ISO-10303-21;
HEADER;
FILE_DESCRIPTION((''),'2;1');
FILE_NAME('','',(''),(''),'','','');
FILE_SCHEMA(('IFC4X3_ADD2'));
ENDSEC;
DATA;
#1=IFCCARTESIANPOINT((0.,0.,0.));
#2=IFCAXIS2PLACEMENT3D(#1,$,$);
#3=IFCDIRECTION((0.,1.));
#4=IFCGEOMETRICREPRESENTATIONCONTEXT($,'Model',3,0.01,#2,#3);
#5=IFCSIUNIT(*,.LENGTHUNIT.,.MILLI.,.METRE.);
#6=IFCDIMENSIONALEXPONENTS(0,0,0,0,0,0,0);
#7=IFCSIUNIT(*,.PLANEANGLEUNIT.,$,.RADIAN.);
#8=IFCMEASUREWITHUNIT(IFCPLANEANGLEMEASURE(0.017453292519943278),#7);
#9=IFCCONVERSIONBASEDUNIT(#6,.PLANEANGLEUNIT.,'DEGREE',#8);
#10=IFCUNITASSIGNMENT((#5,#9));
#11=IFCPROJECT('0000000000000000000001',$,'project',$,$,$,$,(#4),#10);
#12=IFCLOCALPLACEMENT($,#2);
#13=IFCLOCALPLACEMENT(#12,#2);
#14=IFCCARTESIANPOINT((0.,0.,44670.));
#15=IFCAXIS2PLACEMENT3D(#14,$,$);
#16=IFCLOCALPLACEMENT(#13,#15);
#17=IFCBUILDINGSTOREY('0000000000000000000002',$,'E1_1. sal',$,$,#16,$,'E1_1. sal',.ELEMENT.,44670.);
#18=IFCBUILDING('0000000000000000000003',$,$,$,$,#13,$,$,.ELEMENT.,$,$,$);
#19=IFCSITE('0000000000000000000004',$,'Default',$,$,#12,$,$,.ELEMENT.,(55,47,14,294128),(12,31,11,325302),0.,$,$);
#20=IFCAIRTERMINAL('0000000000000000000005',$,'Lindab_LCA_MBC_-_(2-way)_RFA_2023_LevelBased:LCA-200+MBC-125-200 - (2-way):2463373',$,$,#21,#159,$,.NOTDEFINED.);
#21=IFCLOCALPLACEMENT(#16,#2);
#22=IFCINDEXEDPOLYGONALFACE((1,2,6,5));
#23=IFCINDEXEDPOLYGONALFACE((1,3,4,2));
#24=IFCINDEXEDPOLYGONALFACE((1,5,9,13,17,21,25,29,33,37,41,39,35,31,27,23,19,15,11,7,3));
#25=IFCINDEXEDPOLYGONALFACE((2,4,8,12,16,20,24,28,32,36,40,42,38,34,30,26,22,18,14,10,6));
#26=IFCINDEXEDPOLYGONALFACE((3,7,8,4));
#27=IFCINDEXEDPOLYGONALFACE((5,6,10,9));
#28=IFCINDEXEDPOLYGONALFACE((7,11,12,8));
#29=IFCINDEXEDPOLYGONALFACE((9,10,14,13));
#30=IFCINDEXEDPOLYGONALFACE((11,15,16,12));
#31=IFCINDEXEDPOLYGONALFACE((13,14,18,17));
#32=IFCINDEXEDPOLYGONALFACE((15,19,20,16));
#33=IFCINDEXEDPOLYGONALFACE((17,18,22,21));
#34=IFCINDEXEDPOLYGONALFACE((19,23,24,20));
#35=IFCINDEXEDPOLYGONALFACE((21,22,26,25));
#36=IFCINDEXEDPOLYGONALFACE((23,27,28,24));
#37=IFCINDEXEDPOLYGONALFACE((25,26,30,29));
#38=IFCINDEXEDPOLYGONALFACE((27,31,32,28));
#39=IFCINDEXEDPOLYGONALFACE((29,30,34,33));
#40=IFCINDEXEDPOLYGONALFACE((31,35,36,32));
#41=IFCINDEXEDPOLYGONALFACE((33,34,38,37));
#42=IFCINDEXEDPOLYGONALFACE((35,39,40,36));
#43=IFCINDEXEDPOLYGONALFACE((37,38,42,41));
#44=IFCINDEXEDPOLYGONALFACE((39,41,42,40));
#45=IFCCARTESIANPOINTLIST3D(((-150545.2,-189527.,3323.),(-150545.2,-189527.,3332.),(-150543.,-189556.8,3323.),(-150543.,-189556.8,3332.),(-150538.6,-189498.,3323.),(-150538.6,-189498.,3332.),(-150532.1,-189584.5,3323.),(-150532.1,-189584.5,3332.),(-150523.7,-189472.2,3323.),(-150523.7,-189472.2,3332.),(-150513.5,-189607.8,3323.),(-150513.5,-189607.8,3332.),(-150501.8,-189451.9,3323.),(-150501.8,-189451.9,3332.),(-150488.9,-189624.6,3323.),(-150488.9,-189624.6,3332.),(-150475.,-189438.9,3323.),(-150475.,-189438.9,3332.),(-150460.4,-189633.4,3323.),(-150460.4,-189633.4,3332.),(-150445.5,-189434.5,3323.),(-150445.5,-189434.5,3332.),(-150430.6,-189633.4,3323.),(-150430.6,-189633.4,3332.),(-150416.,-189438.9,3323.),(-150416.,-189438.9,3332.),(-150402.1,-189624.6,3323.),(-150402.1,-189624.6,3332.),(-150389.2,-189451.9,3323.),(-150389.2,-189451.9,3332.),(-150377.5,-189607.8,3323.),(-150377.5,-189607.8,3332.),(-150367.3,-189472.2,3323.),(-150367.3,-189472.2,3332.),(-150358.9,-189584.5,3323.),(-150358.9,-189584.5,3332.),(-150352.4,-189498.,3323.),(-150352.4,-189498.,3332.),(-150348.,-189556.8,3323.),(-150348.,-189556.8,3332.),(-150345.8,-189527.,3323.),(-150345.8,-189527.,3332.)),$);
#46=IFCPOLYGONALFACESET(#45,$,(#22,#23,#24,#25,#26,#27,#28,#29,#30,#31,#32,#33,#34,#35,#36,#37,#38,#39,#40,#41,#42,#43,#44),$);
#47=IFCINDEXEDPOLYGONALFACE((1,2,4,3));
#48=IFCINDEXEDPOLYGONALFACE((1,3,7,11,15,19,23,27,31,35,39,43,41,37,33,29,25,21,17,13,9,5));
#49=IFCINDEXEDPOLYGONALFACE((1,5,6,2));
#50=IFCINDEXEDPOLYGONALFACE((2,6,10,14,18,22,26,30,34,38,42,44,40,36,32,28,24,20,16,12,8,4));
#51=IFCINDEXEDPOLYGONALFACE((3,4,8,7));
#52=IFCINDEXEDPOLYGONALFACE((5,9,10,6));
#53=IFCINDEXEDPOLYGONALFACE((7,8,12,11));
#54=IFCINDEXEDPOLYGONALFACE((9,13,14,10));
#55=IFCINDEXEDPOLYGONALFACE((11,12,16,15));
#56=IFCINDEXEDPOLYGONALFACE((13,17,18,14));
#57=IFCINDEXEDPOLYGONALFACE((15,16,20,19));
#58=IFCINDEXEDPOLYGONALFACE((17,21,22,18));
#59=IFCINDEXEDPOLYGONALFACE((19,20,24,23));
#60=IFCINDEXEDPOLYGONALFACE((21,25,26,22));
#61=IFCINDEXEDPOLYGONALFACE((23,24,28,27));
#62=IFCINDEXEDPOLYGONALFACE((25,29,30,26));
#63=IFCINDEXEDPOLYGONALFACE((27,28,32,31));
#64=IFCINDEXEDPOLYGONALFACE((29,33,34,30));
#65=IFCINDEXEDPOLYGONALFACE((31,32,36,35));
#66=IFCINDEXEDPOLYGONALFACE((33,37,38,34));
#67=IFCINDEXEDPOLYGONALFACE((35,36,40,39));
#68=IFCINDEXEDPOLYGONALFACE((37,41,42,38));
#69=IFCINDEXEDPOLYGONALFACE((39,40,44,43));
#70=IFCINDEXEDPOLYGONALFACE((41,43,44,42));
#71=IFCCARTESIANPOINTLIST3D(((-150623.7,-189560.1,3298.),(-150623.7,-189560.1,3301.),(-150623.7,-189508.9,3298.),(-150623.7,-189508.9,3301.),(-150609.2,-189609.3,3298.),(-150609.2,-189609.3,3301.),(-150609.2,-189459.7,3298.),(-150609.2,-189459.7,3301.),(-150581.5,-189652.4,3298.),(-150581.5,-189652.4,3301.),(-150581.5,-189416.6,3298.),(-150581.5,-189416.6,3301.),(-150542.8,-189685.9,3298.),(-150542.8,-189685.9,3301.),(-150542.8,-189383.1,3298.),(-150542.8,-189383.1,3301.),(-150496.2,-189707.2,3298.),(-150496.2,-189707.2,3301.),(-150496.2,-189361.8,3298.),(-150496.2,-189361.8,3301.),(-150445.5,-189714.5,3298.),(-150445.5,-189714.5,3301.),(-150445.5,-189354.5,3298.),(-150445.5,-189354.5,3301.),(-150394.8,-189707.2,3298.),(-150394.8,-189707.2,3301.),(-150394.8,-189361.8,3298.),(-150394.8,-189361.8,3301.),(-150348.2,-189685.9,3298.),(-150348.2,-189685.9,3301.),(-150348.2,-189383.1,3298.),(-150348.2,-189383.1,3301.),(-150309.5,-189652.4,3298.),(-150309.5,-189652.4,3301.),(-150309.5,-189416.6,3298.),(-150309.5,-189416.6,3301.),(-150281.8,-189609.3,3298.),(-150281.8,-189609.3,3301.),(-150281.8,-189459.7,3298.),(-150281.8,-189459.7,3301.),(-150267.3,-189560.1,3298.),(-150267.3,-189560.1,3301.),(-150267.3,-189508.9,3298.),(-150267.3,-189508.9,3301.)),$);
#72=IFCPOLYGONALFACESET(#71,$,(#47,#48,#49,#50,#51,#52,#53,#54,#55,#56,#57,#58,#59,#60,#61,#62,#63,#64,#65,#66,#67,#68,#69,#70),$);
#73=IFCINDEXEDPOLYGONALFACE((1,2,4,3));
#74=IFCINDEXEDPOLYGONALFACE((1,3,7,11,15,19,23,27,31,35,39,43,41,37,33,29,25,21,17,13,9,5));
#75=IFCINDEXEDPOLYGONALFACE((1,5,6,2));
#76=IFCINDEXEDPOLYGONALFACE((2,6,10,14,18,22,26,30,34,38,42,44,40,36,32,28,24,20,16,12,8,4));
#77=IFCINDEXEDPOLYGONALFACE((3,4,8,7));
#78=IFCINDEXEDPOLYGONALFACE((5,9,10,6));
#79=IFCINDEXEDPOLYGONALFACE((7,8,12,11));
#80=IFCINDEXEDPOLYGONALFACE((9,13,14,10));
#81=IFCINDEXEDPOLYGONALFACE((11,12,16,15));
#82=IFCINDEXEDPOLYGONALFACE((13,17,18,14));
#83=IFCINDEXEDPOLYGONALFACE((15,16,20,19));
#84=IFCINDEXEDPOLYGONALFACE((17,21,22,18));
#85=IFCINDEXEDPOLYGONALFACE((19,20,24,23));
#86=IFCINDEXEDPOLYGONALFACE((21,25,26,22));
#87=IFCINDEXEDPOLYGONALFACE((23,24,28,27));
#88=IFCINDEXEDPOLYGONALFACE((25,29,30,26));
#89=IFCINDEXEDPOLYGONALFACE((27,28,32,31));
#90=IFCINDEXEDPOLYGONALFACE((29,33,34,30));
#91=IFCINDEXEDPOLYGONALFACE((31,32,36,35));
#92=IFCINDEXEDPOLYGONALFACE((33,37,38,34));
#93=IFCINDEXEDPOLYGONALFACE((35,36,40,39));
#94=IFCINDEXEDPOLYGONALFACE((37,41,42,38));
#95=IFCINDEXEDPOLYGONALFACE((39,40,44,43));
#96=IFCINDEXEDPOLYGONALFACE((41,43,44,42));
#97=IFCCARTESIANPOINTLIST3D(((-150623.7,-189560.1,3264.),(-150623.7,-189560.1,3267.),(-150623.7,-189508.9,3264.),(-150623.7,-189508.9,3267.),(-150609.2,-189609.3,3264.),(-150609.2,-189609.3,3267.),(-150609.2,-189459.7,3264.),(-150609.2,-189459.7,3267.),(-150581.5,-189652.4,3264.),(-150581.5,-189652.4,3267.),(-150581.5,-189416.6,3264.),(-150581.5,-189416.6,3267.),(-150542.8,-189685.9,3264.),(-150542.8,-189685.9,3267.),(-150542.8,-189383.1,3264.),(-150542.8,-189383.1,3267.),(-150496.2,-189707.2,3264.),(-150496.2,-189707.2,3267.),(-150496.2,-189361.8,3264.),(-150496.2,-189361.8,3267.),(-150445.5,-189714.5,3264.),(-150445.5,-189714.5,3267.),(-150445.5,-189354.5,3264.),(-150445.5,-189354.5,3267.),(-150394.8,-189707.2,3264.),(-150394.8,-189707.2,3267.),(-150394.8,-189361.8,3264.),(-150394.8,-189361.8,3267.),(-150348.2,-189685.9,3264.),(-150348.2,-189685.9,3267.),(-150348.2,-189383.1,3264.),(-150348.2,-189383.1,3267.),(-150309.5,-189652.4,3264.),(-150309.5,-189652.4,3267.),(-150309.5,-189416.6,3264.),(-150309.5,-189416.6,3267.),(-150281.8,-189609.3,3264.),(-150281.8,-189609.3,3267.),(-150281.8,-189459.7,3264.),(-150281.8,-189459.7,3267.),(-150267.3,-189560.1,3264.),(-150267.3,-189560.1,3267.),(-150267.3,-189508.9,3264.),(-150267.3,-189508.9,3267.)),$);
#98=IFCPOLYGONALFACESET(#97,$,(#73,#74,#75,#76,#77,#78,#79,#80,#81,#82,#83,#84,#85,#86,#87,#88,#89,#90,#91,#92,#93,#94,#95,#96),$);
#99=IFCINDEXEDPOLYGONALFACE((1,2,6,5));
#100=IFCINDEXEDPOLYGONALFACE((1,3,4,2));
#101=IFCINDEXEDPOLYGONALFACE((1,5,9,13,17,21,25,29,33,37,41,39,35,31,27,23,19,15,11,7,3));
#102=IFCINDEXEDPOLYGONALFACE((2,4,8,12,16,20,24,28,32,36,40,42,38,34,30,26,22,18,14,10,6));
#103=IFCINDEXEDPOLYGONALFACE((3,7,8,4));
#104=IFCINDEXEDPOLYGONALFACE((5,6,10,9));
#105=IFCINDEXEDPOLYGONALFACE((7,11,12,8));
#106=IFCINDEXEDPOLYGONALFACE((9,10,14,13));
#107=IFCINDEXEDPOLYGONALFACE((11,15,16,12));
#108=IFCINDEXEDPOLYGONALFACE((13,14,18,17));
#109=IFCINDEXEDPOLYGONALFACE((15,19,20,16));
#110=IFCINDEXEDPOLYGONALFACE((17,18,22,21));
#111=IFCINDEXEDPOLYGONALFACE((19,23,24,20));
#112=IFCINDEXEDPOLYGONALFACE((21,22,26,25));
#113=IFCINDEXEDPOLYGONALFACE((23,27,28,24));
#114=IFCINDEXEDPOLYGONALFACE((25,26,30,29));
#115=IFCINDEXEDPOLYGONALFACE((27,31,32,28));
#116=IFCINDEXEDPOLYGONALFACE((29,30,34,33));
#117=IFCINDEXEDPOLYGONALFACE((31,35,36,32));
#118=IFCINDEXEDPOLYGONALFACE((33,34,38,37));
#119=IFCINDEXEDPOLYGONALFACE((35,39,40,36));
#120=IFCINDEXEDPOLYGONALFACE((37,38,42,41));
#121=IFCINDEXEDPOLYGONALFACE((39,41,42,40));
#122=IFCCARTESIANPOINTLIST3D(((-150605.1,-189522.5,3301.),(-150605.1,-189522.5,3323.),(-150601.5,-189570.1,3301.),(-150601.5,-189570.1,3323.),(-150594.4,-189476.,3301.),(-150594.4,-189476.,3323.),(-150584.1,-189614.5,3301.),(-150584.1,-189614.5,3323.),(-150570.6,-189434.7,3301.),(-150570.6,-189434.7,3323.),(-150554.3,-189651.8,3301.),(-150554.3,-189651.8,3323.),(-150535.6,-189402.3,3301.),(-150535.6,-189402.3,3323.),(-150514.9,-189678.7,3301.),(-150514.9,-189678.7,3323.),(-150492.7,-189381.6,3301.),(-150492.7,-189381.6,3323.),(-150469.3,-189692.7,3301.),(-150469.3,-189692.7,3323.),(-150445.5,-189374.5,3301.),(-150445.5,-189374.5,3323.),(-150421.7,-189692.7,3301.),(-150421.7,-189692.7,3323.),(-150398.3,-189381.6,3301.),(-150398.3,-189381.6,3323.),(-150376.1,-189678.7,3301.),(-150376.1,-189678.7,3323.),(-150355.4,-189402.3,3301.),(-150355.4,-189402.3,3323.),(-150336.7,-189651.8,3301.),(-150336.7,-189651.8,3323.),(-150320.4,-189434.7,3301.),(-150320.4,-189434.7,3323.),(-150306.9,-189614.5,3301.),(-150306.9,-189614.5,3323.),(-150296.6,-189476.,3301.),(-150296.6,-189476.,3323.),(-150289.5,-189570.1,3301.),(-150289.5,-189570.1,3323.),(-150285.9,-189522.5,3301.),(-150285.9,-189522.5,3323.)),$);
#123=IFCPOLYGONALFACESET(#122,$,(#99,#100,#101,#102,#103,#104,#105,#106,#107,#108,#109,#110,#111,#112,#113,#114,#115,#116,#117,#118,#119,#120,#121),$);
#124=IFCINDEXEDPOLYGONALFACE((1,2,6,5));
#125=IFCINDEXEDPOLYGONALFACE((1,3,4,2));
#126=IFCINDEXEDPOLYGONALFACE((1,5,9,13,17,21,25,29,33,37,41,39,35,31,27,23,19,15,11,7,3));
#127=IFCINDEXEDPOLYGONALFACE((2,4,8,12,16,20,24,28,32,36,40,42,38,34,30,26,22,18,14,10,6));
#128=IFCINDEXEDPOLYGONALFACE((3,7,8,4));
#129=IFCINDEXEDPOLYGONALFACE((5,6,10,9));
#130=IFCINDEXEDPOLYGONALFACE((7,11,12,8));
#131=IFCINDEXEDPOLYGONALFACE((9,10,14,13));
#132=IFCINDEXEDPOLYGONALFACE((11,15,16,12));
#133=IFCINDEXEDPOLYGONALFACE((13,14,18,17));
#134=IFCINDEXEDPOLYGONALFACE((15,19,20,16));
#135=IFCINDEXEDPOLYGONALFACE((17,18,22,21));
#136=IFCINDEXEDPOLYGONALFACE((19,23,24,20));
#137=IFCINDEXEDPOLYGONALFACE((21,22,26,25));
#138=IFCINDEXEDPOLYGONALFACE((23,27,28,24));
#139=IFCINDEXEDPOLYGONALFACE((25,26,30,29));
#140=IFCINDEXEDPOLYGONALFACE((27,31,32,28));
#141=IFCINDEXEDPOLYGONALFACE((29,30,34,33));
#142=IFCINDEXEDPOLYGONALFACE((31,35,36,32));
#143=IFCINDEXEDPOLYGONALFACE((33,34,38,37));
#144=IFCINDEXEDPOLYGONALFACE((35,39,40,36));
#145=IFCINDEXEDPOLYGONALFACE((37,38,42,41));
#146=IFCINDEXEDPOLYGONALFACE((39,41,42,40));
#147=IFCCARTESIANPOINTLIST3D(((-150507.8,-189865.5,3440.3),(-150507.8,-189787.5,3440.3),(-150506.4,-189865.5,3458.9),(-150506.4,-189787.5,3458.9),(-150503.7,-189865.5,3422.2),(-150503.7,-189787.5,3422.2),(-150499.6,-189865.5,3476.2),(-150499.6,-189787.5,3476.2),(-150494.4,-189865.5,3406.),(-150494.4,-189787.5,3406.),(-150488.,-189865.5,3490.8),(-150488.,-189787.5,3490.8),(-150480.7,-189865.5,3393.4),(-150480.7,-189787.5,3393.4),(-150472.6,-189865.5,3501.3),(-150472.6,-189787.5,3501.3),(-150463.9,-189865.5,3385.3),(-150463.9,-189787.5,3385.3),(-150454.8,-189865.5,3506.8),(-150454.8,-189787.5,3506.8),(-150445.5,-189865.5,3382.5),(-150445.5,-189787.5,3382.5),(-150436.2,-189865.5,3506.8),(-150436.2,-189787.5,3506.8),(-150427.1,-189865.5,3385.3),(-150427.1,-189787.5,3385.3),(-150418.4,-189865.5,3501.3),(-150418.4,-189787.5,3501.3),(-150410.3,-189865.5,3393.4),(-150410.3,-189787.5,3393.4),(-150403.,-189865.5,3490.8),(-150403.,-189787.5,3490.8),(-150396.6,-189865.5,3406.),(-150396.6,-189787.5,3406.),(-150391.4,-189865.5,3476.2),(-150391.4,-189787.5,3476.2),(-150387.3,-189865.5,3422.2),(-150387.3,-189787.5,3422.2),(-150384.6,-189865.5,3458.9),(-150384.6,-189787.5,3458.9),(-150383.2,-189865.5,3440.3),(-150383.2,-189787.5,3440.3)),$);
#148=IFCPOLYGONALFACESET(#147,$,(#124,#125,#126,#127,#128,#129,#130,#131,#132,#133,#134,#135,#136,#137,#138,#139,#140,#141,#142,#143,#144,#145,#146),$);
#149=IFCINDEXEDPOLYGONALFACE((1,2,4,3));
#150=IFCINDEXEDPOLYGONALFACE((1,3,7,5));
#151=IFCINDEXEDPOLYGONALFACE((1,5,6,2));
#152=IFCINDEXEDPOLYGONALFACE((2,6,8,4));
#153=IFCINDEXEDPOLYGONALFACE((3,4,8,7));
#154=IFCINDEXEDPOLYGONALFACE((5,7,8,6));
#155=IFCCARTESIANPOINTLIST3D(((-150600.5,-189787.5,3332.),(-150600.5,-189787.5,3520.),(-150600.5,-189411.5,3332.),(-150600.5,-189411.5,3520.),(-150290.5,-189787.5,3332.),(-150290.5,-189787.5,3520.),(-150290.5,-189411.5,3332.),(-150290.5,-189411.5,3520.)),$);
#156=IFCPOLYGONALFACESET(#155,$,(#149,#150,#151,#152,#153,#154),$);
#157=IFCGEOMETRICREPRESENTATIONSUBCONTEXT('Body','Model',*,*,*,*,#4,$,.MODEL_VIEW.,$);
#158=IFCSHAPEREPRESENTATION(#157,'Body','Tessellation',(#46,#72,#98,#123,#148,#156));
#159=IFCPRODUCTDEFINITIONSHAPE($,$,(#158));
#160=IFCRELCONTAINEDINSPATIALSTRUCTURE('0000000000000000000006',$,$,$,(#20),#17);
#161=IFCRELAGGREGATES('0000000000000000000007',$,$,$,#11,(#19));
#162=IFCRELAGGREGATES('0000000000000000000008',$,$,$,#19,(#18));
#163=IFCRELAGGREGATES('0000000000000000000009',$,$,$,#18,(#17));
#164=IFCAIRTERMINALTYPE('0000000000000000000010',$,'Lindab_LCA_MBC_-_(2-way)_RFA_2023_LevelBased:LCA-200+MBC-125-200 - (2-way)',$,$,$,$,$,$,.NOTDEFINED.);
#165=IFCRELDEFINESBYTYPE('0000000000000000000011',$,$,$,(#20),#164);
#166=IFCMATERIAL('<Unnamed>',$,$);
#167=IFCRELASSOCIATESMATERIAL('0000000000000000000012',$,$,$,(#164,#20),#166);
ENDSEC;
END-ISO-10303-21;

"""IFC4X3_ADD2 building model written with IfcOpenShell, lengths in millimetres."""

from ifc_helpers import new_model, entity, si_unit, converted_unit, direction, frame, frame_2d, origin, origin_2d_with_axis, place, context, subcontext, project, spatial, rectangle, circle, extrude, source, transform, mapped, material, type_object, type_shapes, element, save


model = new_model("IFC4X3_ADD2")

# Units and contexts
model_context = context("Model", 3, precision=0.01, world=origin(), true_north=direction((0.0, 1.0)))
body_context = subcontext(model_context, "Body", "Model", "MODEL_VIEW")
ifc_project = project(units=[si_unit("LENGTHUNIT", "METRE", prefix="MILLI"), converted_unit("PLANEANGLEUNIT", "DEGREE", entity("IfcPlaneAngleMeasure", 0.017453292519943278), si_unit("PLANEANGLEUNIT", "RADIAN"), dimensions=[0, 0, 0, 0, 0, 0, 0])], contexts=[model_context])

# Site, building, storey
site_placement = place(None, origin())
site = spatial("IfcSite", under=ifc_project, at=site_placement, Name="Default", CompositionType="ELEMENT", RefLatitude=(55, 47, 14, 294128), RefLongitude=(12, 31, 11, 325302), RefElevation=0.0)
building_placement = place(site_placement, origin())
building = spatial("IfcBuilding", under=site, at=building_placement, CompositionType="ELEMENT")
storey_placement = place(building_placement, frame((0.0, 0.0, 44670.0)))
storey = spatial("IfcBuildingStorey", under=building, at=storey_placement, Name="E1_1. sal", LongName="E1_1. sal", CompositionType="ELEMENT", Elevation=44670.0)

# Air terminal
ifc_material_1 = material(Name="<Unnamed>")
air_terminal_type = type_object("IfcAirTerminalType", Name="Lindab_LCA_MBC_-_(2-way)_RFA_2023_LevelBased:LCA-200+MBC-125-200 - (2-way)", PredefinedType="NOTDEFINED", material=ifc_material_1)
shared_shape_1 = source(origin(), body_context, "Body", "SweptSolid", [
    extrude(circle(Radius=100.0, at=frame_2d((0.0, 0.0), x_axis=(1.0, 0.0))), frame((0.0, 0.0, 22.0)), (0.0, 0.0, 1.0), 9.0),
    extrude(circle(Radius=180.0, at=frame_2d((0.0, 0.0), x_axis=(1.0, 0.0))), frame((0.0, 0.0, -3.0)), (0.0, 0.0, 1.0), 3.0),
    extrude(circle(Radius=180.0, at=frame_2d((0.0, 0.0), x_axis=(1.0, 0.0))), frame((0.0, 0.0, -37.0)), (0.0, 0.0, 1.0), 3.0),
    extrude(circle(Radius=160.0, at=frame_2d((0.0, 0.0), x_axis=(1.0, 0.0))), origin(), (0.0, 0.0, 1.0), 22.0),
    extrude(circle(Radius=62.5, at=frame_2d((0.0, 0.0), x_axis=(1.0, 0.0))), frame((-331.0, 0.0, 144.0), z_axis=(1.0, 0.0, 0.0), x_axis=(0.0, 0.0, -1.0)), (0.0, 0.0, 1.0), 78.0),
    extrude(rectangle(XDim=310.0, YDim=376.0, at=origin_2d_with_axis()), frame((-65.0, 0.0, 31.0), z_axis=(0.0, 0.0, 1.0), x_axis=(0.0, -1.0, 0.0)), (0.0, 0.0, 1.0), 188.0),
])
type_shapes(air_terminal_type, [shared_shape_1])
for number, where, z_axis, x_axis, name in (
    (1, (-150445.5, -189534.5, 3301.0), (0.0, 0.0, 1.0), (0.0, 1.0, 0.0), "Lindab_LCA_MBC_-_(2-way)_RFA_2023_LevelBased:LCA-200+MBC-125-200 - (2-way):2463373"),
):
    element("IfcAirTerminal", number, at=place(storey_placement, frame(where, z_axis=z_axis, x_axis=x_axis)), inside=storey, type_object=air_terminal_type, material=ifc_material_1, Name=name, PredefinedType="NOTDEFINED", context=body_context, shape_type="MappedRepresentation", body=[
        mapped(shared_shape_1, transform((0.0, 0.0, 0.0), scale=1.0)),
    ])

save(model, "model.ifc")
